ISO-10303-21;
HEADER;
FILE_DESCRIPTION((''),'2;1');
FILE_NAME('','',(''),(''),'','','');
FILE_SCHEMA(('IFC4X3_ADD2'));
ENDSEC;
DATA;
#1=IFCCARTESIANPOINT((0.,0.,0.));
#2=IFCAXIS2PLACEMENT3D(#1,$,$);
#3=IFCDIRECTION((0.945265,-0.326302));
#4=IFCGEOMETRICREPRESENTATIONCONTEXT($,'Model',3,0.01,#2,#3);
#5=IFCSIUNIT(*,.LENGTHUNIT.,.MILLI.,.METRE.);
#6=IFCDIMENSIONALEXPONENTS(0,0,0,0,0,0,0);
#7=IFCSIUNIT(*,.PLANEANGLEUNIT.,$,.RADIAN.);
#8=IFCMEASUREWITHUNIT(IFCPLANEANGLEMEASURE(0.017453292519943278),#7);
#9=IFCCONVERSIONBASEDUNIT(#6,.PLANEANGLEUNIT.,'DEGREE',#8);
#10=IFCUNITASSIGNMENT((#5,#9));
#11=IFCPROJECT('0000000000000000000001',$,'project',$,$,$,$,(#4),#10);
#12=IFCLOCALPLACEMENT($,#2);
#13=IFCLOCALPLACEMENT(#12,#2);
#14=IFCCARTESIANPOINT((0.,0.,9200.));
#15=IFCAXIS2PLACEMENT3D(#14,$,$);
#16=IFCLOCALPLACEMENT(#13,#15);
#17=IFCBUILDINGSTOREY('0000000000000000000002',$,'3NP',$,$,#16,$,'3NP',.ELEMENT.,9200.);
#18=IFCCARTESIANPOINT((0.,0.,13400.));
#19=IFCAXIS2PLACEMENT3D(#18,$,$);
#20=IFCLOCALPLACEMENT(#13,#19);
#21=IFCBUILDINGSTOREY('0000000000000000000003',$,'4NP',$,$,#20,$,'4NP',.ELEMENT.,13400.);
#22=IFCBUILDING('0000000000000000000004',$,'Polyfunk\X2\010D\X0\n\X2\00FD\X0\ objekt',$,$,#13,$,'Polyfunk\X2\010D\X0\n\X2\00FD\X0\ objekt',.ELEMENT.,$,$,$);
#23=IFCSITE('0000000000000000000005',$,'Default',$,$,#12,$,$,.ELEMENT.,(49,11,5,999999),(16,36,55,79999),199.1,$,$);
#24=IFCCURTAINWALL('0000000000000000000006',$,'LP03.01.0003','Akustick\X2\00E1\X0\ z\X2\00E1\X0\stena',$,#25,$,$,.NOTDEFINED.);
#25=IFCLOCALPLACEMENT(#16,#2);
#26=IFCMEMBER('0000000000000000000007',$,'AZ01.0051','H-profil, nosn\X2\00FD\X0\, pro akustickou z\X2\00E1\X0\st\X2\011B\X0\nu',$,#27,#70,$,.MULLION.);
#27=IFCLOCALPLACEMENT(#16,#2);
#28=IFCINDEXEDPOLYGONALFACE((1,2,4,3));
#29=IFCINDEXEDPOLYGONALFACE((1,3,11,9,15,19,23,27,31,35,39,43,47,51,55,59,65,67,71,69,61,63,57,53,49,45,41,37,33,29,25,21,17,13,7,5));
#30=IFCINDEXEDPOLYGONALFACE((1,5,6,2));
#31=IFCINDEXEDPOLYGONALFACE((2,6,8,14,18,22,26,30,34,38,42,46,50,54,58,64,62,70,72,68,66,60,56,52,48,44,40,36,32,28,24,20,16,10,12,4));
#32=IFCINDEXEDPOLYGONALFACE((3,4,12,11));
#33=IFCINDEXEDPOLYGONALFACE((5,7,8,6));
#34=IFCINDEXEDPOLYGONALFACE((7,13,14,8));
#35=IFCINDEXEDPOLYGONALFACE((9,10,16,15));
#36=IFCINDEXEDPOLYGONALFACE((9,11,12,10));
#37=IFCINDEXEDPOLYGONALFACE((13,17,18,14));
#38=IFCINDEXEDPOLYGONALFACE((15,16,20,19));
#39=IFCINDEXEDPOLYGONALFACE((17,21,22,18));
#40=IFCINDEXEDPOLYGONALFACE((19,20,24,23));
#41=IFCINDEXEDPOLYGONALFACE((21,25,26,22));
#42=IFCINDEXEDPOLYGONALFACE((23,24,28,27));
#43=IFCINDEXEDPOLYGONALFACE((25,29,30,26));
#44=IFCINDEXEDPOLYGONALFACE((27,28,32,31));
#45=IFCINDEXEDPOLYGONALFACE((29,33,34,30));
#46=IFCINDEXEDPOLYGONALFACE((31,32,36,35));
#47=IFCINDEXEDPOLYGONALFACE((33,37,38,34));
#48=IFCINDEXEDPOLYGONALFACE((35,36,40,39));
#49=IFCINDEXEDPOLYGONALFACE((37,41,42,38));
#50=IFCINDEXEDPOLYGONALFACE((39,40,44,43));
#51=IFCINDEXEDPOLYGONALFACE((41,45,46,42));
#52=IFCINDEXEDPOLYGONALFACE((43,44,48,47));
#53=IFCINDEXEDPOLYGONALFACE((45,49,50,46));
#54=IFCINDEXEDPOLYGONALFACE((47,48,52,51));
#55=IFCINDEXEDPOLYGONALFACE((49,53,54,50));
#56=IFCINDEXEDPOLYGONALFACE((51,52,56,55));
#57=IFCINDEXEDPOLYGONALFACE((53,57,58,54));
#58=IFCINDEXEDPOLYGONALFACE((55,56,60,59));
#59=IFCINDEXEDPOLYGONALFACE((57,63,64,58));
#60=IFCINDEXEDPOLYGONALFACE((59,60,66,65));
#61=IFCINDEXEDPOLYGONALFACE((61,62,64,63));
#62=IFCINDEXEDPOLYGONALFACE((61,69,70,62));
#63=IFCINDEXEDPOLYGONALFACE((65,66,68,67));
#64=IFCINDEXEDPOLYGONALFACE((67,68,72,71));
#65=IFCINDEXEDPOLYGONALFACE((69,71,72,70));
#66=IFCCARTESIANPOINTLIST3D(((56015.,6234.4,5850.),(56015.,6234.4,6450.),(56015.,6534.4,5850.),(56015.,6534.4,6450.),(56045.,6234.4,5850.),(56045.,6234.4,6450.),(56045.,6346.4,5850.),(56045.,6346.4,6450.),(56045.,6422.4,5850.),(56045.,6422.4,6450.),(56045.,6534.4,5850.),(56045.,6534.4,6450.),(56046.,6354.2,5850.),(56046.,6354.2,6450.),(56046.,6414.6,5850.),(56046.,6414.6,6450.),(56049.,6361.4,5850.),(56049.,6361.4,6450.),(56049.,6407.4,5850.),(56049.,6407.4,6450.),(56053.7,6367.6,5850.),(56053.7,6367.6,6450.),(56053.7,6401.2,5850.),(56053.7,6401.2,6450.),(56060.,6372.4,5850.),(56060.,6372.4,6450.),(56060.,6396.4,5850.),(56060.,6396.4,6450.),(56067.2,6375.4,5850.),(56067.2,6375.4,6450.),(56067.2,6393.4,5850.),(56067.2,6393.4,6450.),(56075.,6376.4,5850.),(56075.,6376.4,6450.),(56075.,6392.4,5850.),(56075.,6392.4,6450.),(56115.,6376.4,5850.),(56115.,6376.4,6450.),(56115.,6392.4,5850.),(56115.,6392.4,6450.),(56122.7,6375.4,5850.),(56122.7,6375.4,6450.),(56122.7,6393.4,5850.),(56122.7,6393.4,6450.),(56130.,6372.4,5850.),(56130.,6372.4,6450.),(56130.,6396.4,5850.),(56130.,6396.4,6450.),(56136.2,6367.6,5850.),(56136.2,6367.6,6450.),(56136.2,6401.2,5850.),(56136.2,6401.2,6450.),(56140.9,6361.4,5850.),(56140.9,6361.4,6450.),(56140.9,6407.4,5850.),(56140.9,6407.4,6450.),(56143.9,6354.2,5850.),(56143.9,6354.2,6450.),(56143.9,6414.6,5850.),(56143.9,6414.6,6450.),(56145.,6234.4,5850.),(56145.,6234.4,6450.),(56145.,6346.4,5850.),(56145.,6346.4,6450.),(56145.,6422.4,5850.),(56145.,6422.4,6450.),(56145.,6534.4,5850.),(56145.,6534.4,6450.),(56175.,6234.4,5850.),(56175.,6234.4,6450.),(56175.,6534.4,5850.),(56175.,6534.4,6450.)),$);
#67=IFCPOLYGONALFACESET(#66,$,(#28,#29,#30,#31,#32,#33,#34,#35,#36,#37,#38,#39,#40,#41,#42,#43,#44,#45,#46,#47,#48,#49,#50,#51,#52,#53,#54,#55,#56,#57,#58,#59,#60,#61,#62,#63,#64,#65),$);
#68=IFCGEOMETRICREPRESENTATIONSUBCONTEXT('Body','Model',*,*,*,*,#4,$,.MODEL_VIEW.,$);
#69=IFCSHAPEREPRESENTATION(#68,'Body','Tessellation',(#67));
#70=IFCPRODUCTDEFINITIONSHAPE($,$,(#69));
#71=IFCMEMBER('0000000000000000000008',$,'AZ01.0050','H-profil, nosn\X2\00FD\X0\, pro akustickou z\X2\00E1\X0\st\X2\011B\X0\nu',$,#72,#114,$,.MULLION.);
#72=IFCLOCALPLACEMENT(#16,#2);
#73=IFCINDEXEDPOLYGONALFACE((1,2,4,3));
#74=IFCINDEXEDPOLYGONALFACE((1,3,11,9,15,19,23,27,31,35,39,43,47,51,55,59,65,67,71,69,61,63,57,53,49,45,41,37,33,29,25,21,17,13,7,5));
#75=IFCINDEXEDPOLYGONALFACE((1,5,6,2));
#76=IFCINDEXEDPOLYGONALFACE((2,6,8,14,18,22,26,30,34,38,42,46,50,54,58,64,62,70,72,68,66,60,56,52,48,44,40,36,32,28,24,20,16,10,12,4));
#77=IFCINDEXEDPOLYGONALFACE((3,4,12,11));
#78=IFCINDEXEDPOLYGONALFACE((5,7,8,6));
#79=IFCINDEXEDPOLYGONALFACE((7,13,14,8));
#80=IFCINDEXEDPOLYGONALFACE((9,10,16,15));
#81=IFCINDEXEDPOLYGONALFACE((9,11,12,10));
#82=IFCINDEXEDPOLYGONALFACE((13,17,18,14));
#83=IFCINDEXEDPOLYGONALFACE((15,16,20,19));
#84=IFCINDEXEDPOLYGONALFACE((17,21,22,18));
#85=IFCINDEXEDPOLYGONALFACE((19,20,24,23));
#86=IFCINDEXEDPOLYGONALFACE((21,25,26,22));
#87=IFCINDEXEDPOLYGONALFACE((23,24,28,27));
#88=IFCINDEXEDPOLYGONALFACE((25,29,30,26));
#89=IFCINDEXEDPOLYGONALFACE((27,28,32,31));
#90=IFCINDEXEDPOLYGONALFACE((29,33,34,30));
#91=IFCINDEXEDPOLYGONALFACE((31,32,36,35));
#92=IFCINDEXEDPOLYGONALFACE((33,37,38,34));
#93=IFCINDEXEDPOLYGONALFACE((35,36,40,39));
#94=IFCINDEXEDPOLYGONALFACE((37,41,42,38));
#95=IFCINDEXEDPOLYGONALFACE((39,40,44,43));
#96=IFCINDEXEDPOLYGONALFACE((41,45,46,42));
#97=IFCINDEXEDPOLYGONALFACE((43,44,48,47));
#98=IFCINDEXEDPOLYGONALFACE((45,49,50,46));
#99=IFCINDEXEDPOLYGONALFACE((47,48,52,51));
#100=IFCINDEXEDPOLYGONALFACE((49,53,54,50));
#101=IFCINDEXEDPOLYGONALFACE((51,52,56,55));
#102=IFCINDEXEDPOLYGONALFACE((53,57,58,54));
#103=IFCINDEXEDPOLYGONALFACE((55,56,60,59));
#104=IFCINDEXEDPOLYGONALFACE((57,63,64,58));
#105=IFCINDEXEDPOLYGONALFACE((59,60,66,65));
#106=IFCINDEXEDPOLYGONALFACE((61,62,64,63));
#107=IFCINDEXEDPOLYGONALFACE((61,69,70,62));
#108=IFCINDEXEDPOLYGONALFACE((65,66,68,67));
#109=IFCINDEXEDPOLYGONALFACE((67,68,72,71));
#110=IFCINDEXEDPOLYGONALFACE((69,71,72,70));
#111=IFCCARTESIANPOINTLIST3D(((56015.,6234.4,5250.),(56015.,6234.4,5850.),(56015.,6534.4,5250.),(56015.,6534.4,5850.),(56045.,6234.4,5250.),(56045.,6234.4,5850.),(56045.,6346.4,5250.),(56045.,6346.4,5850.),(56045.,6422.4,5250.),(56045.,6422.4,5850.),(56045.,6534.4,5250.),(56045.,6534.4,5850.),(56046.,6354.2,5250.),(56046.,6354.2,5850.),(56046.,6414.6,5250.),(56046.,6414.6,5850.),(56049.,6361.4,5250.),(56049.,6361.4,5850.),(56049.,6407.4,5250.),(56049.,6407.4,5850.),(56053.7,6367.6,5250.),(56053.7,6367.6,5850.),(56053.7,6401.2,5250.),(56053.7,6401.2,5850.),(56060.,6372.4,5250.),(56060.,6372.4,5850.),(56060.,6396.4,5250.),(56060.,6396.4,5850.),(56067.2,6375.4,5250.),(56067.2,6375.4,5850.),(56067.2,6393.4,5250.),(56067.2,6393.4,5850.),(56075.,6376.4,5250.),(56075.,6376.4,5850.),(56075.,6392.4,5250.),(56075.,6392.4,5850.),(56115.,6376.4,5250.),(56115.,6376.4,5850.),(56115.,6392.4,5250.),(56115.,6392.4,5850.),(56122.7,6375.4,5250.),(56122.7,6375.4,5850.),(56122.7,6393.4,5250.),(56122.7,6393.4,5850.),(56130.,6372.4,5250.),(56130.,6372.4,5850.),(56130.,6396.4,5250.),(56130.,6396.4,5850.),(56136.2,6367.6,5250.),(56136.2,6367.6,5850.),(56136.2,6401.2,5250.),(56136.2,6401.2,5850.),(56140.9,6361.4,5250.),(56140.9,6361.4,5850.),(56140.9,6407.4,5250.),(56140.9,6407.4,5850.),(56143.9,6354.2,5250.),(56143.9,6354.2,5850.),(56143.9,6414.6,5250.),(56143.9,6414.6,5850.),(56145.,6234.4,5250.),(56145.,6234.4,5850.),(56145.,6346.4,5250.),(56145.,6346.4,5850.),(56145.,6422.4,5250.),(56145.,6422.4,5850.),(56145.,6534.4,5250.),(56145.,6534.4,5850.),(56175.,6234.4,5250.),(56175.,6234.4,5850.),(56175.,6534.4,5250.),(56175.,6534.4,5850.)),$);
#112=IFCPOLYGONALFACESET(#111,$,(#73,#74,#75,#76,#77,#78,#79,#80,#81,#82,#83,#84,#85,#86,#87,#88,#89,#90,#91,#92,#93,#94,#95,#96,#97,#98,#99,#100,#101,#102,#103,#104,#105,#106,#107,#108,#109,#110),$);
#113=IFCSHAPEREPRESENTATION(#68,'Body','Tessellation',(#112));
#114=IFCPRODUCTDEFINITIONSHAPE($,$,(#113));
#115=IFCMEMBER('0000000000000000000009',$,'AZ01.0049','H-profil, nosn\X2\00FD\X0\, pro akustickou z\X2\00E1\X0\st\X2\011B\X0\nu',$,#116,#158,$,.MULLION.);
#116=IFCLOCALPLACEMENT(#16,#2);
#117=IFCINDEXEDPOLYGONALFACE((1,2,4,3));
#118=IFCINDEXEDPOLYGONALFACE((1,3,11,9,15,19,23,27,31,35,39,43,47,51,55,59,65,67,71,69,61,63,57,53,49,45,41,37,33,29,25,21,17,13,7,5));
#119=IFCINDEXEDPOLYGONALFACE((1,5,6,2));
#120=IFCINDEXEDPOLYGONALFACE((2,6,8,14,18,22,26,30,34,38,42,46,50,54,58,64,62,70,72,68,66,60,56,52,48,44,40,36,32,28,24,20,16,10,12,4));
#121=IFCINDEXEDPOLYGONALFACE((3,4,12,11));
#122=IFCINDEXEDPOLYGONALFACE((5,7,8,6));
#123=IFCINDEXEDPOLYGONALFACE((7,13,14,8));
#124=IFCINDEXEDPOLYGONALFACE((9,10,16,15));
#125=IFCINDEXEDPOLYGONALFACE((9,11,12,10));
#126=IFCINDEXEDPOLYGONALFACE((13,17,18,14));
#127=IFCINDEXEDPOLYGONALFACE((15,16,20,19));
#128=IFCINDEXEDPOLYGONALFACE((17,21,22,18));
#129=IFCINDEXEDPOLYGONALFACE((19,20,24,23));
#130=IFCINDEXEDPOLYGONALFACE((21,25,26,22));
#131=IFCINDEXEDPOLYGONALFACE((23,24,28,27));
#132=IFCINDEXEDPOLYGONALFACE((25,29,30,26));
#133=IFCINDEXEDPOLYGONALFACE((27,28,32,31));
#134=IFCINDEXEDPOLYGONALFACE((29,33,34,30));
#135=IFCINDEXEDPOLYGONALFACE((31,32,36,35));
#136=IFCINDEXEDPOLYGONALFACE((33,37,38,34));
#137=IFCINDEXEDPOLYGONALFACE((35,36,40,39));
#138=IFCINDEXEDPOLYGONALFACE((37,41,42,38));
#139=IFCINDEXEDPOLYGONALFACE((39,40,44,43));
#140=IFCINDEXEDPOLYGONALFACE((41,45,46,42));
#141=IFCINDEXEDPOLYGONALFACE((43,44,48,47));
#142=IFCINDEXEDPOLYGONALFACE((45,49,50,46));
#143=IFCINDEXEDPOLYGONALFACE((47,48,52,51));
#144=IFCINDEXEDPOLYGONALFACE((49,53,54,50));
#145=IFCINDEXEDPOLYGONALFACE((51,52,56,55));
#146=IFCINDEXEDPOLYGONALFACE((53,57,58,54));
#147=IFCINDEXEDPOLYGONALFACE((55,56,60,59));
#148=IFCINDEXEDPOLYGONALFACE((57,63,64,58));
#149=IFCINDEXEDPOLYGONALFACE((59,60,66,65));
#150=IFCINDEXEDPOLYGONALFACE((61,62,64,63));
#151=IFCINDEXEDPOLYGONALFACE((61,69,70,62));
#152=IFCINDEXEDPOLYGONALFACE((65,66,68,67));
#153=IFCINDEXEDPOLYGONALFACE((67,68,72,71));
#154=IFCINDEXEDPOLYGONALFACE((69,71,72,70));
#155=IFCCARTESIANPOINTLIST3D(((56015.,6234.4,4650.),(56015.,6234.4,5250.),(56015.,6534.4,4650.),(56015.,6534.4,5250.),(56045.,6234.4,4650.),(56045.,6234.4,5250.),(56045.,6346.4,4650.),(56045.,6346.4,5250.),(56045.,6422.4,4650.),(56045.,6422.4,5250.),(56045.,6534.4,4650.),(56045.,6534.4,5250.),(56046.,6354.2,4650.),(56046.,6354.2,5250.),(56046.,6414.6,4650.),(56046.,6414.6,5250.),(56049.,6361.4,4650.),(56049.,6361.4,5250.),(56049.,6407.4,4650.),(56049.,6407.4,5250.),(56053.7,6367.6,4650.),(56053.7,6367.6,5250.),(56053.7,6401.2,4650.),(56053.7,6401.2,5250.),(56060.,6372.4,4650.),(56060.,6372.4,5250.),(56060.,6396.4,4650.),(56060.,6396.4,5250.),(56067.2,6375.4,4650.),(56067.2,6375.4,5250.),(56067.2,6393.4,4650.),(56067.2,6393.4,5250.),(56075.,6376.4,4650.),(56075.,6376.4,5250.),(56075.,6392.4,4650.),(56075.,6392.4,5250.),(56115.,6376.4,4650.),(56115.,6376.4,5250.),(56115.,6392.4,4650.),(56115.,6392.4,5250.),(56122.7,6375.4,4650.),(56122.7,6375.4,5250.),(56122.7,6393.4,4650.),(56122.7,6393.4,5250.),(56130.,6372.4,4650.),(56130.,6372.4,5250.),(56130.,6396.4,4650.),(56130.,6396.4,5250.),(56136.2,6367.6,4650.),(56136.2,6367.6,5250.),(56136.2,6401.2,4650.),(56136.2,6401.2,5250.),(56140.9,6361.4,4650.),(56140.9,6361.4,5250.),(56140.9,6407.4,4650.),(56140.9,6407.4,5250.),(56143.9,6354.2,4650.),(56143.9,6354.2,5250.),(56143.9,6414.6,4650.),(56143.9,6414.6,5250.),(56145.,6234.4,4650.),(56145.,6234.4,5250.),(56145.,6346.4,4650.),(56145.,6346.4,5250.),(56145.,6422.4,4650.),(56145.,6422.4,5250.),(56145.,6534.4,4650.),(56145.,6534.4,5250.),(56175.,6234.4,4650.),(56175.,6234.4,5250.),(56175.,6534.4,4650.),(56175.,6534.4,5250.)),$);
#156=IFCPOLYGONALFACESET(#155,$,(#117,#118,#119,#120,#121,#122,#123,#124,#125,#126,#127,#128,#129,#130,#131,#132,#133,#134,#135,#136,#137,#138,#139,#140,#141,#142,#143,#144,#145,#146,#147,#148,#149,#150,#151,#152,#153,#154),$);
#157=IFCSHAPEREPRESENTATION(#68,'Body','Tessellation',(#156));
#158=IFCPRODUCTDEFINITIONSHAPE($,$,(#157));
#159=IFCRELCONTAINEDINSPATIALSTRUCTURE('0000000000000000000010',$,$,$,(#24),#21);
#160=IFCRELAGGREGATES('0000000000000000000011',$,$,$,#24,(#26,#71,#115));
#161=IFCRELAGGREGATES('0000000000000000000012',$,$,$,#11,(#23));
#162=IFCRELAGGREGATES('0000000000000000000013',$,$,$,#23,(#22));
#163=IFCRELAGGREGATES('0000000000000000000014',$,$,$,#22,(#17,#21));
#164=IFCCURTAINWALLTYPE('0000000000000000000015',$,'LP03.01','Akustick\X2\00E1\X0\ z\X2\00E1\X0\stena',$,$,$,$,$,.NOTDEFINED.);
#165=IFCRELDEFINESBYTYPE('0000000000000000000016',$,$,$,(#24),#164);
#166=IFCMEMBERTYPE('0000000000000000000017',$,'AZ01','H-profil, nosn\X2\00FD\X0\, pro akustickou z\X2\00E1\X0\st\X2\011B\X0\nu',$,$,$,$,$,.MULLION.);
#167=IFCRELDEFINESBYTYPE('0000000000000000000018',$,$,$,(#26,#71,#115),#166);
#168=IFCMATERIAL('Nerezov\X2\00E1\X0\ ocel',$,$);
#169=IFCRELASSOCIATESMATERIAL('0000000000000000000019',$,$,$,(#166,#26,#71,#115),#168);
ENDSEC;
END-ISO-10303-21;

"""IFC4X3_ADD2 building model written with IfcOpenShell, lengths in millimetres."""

from ifc_helpers import new_model, entity, si_unit, converted_unit, direction, frame, frame_2d, origin, place, context, subcontext, project, spatial, polyline, circle_curve, parameter, trimmed, segment, composite_curve, outline, extrude, source, transform, mapped, material, material_profile, profile_set, profile_usage, type_object, element, aggregate, save


model = new_model("IFC4X3_ADD2")

# Units and contexts
model_context = context("Model", 3, precision=0.01, world=origin(), true_north=direction((0.945265, -0.326302)))
body_context = subcontext(model_context, "Body", "Model", "MODEL_VIEW")
ifc_project = project(units=[si_unit("LENGTHUNIT", "METRE", prefix="MILLI"), converted_unit("PLANEANGLEUNIT", "DEGREE", entity("IfcPlaneAngleMeasure", 0.017453292519943278), si_unit("PLANEANGLEUNIT", "RADIAN"), dimensions=[0, 0, 0, 0, 0, 0, 0])], contexts=[model_context])

# Site, building, storey
site_placement = place(None, origin())
site = spatial("IfcSite", under=ifc_project, at=site_placement, Name="Default", CompositionType="ELEMENT", RefLatitude=(49, 11, 5, 999999), RefLongitude=(16, 36, 55, 79999), RefElevation=199.1)
building_placement = place(site_placement, origin())
building = spatial("IfcBuilding", under=site, at=building_placement, Name="Polyfunkčný objekt", LongName="Polyfunkčný objekt", CompositionType="ELEMENT")
storey_1_placement = place(building_placement, frame((0.0, 0.0, 9200.0)))
storey_1 = spatial("IfcBuildingStorey", under=building, at=storey_1_placement, Name="3NP", LongName="3NP", CompositionType="ELEMENT", Elevation=9200.0)

# Shared definitions
storey_2_placement = place(building_placement, frame((0.0, 0.0, 13400.0)))
storey_2 = spatial("IfcBuildingStorey", under=building, at=storey_2_placement, Name="4NP", LongName="4NP", CompositionType="ELEMENT", Elevation=13400.0)

# Shared definitions
curtain_wall_type_1 = type_object("IfcCurtainWallType", Name="LP03.01", Description="Akustická zástena", PredefinedType="NOTDEFINED")
ifc_material_1 = material(Name="Nerezová ocel")
ifc_material_profile_1 = material_profile(ifc_material_1, outline(composite_curve([segment(polyline([(50.0, -150.0), (80.0, -150.0)]), True, "CONTINUOUS"), segment(polyline([(80.0, -150.0), (80.0, 150.0)]), True, "CONTINUOUS"), segment(polyline([(80.0, 150.0), (50.0, 150.0)]), True, "CONTINUOUS"), segment(polyline([(50.0, 150.0), (50.0, 38.0)]), True, "CONTINUOUS"), segment(trimmed(circle_curve(frame_2d((20.0, 38.0), x_axis=(0.0, 1.0)), 30.0), [parameter(180.0)], [parameter(270.0)], True, "PARAMETER"), False, "CONTINUOUS"), segment(polyline([(20.0, 8.0), (-20.0, 8.0)]), True, "CONTINUOUS"), segment(trimmed(circle_curve(frame_2d((-20.0, 38.0), x_axis=(0.0, 1.0)), 30.0), [parameter(90.0)], [parameter(180.0)], True, "PARAMETER"), False, "CONTINUOUS"), segment(polyline([(-50.0, 38.0), (-50.0, 150.0)]), True, "CONTINUOUS"), segment(polyline([(-50.0, 150.0), (-80.0, 150.0)]), True, "CONTINUOUS"), segment(polyline([(-80.0, 150.0), (-80.0, -150.0)]), True, "CONTINUOUS"), segment(polyline([(-80.0, -150.0), (-50.0, -150.0)]), True, "CONTINUOUS"), segment(polyline([(-50.0, -150.0), (-50.0, -38.0)]), True, "CONTINUOUS"), segment(trimmed(circle_curve(frame_2d((-20.0, -38.0), x_axis=(0.0, 1.0)), 30.0), [parameter(0.0)], [parameter(90.0)], True, "PARAMETER"), False, "CONTINUOUS"), segment(polyline([(-20.0, -8.0), (20.0, -8.0)]), True, "CONTINUOUS"), segment(trimmed(circle_curve(frame_2d((20.0, -38.0), x_axis=(0.0, 1.0)), 30.0), [parameter(270.0)], [parameter(0.0)], True, "PARAMETER"), False, "CONTINUOUS"), segment(polyline([(50.0, -38.0), (50.0, -150.0)]), True, "CONTINUOUS")], self_intersect=False)), Name="Profil zástena")
ifc_profile_set_1 = profile_set([ifc_material_profile_1], Name="Profil zástena")
ifc_profile_usage_1 = profile_usage(ifc_profile_set_1)
member_type_1 = type_object("IfcMemberType", Name="AZ01", Description="H-profil, nosný, pro akustickou zástěnu", PredefinedType="MULLION", material=ifc_profile_set_1)

# Curtain wall, members
curtain_wall_1_placement = place(storey_2_placement, frame((0.0, 0.0, -13400.0)))
curtain_wall_1 = element("IfcCurtainWall", 1, at=curtain_wall_1_placement, inside=storey_2, type_object=curtain_wall_type_1, Name="LP03.01.0003", Description="Akustická zástena", PredefinedType="NOTDEFINED")
shared_shape_1 = source(origin(), body_context, "Body", "SweptSolid", [
    extrude(outline(composite_curve([segment(polyline([(-150.0, -50.0), (-150.0, -80.0)]), True, "CONTINUOUS"), segment(polyline([(-150.0, -80.0), (150.0, -80.0)]), True, "CONTINUOUS"), segment(polyline([(150.0, -80.0), (150.0, -50.0)]), True, "CONTINUOUS"), segment(polyline([(150.0, -50.0), (38.0, -50.0)]), True, "CONTINUOUS"), segment(trimmed(circle_curve(frame_2d((38.0, -20.0), x_axis=(1.0, 0.0)), 30.0), [parameter(180.0)], [parameter(270.0)], True, "PARAMETER"), False, "CONTINUOUS"), segment(polyline([(8.0, -20.0), (8.0, 20.0)]), True, "CONTINUOUS"), segment(trimmed(circle_curve(frame_2d((38.0, 20.0), x_axis=(1.0, 0.0)), 30.0), [parameter(90.0)], [parameter(180.0)], True, "PARAMETER"), False, "CONTINUOUS"), segment(polyline([(38.0, 50.0), (150.0, 50.0)]), True, "CONTINUOUS"), segment(polyline([(150.0, 50.0), (150.0, 80.0)]), True, "CONTINUOUS"), segment(polyline([(150.0, 80.0), (-150.0, 80.0)]), True, "CONTINUOUS"), segment(polyline([(-150.0, 80.0), (-150.0, 50.0)]), True, "CONTINUOUS"), segment(polyline([(-150.0, 50.0), (-38.0, 50.0)]), True, "CONTINUOUS"), segment(trimmed(circle_curve(frame_2d((-38.0, 20.0), x_axis=(1.0, 0.0)), 30.0), [parameter(0.0)], [parameter(90.0)], True, "PARAMETER"), False, "CONTINUOUS"), segment(polyline([(-8.0, 20.0), (-8.0, -20.0)]), True, "CONTINUOUS"), segment(trimmed(circle_curve(frame_2d((-38.0, -20.0), x_axis=(1.0, 0.0)), 30.0), [parameter(270.0)], [parameter(0.0)], True, "PARAMETER"), False, "CONTINUOUS"), segment(polyline([(-38.0, -50.0), (-150.0, -50.0)]), True, "CONTINUOUS")], self_intersect=False)), frame((-150.0, 0.0, -600.0), z_axis=(0.0, 0.0, -1.0), x_axis=(1.0, 0.0, 0.0)), (0.0, 0.0, -1.0), 600.0),
])
member_1_placement = place(curtain_wall_1_placement, frame((56095.0, 6534.4, 15050.0), z_axis=(0.0, 0.0, -1.0), x_axis=(0.0, 1.0, 0.0)))
member_1 = element("IfcMember", 2, at=member_1_placement, type_object=member_type_1, material=ifc_profile_usage_1, Name="AZ01.0051", Description="H-profil, nosný, pro akustickou zástěnu", PredefinedType="MULLION", context=body_context, shape_type="MappedRepresentation", body=[
    mapped(shared_shape_1, transform((0.0, 0.0, 0.0), scale=1.0)),
])
member_2_placement = place(curtain_wall_1_placement, frame((56095.0, 6534.4, 14450.0), z_axis=(0.0, 0.0, -1.0), x_axis=(0.0, 1.0, 0.0)))
member_2 = element("IfcMember", 3, at=member_2_placement, type_object=member_type_1, material=ifc_profile_usage_1, Name="AZ01.0050", Description="H-profil, nosný, pro akustickou zástěnu", PredefinedType="MULLION", context=body_context, shape_type="MappedRepresentation", body=[
    mapped(shared_shape_1, transform((0.0, 0.0, 0.0), scale=1.0)),
])
member_3_placement = place(curtain_wall_1_placement, frame((56095.0, 6534.4, 13850.0), z_axis=(0.0, 0.0, -1.0), x_axis=(0.0, 1.0, 0.0)))
member_3 = element("IfcMember", 4, at=member_3_placement, type_object=member_type_1, material=ifc_profile_usage_1, Name="AZ01.0049", Description="H-profil, nosný, pro akustickou zástěnu", PredefinedType="MULLION", context=body_context, shape_type="MappedRepresentation", body=[
    mapped(shared_shape_1, transform((0.0, 0.0, 0.0), scale=1.0)),
])
aggregate(curtain_wall_1, [member_1, member_2, member_3])

save(model, "model.ifc")
